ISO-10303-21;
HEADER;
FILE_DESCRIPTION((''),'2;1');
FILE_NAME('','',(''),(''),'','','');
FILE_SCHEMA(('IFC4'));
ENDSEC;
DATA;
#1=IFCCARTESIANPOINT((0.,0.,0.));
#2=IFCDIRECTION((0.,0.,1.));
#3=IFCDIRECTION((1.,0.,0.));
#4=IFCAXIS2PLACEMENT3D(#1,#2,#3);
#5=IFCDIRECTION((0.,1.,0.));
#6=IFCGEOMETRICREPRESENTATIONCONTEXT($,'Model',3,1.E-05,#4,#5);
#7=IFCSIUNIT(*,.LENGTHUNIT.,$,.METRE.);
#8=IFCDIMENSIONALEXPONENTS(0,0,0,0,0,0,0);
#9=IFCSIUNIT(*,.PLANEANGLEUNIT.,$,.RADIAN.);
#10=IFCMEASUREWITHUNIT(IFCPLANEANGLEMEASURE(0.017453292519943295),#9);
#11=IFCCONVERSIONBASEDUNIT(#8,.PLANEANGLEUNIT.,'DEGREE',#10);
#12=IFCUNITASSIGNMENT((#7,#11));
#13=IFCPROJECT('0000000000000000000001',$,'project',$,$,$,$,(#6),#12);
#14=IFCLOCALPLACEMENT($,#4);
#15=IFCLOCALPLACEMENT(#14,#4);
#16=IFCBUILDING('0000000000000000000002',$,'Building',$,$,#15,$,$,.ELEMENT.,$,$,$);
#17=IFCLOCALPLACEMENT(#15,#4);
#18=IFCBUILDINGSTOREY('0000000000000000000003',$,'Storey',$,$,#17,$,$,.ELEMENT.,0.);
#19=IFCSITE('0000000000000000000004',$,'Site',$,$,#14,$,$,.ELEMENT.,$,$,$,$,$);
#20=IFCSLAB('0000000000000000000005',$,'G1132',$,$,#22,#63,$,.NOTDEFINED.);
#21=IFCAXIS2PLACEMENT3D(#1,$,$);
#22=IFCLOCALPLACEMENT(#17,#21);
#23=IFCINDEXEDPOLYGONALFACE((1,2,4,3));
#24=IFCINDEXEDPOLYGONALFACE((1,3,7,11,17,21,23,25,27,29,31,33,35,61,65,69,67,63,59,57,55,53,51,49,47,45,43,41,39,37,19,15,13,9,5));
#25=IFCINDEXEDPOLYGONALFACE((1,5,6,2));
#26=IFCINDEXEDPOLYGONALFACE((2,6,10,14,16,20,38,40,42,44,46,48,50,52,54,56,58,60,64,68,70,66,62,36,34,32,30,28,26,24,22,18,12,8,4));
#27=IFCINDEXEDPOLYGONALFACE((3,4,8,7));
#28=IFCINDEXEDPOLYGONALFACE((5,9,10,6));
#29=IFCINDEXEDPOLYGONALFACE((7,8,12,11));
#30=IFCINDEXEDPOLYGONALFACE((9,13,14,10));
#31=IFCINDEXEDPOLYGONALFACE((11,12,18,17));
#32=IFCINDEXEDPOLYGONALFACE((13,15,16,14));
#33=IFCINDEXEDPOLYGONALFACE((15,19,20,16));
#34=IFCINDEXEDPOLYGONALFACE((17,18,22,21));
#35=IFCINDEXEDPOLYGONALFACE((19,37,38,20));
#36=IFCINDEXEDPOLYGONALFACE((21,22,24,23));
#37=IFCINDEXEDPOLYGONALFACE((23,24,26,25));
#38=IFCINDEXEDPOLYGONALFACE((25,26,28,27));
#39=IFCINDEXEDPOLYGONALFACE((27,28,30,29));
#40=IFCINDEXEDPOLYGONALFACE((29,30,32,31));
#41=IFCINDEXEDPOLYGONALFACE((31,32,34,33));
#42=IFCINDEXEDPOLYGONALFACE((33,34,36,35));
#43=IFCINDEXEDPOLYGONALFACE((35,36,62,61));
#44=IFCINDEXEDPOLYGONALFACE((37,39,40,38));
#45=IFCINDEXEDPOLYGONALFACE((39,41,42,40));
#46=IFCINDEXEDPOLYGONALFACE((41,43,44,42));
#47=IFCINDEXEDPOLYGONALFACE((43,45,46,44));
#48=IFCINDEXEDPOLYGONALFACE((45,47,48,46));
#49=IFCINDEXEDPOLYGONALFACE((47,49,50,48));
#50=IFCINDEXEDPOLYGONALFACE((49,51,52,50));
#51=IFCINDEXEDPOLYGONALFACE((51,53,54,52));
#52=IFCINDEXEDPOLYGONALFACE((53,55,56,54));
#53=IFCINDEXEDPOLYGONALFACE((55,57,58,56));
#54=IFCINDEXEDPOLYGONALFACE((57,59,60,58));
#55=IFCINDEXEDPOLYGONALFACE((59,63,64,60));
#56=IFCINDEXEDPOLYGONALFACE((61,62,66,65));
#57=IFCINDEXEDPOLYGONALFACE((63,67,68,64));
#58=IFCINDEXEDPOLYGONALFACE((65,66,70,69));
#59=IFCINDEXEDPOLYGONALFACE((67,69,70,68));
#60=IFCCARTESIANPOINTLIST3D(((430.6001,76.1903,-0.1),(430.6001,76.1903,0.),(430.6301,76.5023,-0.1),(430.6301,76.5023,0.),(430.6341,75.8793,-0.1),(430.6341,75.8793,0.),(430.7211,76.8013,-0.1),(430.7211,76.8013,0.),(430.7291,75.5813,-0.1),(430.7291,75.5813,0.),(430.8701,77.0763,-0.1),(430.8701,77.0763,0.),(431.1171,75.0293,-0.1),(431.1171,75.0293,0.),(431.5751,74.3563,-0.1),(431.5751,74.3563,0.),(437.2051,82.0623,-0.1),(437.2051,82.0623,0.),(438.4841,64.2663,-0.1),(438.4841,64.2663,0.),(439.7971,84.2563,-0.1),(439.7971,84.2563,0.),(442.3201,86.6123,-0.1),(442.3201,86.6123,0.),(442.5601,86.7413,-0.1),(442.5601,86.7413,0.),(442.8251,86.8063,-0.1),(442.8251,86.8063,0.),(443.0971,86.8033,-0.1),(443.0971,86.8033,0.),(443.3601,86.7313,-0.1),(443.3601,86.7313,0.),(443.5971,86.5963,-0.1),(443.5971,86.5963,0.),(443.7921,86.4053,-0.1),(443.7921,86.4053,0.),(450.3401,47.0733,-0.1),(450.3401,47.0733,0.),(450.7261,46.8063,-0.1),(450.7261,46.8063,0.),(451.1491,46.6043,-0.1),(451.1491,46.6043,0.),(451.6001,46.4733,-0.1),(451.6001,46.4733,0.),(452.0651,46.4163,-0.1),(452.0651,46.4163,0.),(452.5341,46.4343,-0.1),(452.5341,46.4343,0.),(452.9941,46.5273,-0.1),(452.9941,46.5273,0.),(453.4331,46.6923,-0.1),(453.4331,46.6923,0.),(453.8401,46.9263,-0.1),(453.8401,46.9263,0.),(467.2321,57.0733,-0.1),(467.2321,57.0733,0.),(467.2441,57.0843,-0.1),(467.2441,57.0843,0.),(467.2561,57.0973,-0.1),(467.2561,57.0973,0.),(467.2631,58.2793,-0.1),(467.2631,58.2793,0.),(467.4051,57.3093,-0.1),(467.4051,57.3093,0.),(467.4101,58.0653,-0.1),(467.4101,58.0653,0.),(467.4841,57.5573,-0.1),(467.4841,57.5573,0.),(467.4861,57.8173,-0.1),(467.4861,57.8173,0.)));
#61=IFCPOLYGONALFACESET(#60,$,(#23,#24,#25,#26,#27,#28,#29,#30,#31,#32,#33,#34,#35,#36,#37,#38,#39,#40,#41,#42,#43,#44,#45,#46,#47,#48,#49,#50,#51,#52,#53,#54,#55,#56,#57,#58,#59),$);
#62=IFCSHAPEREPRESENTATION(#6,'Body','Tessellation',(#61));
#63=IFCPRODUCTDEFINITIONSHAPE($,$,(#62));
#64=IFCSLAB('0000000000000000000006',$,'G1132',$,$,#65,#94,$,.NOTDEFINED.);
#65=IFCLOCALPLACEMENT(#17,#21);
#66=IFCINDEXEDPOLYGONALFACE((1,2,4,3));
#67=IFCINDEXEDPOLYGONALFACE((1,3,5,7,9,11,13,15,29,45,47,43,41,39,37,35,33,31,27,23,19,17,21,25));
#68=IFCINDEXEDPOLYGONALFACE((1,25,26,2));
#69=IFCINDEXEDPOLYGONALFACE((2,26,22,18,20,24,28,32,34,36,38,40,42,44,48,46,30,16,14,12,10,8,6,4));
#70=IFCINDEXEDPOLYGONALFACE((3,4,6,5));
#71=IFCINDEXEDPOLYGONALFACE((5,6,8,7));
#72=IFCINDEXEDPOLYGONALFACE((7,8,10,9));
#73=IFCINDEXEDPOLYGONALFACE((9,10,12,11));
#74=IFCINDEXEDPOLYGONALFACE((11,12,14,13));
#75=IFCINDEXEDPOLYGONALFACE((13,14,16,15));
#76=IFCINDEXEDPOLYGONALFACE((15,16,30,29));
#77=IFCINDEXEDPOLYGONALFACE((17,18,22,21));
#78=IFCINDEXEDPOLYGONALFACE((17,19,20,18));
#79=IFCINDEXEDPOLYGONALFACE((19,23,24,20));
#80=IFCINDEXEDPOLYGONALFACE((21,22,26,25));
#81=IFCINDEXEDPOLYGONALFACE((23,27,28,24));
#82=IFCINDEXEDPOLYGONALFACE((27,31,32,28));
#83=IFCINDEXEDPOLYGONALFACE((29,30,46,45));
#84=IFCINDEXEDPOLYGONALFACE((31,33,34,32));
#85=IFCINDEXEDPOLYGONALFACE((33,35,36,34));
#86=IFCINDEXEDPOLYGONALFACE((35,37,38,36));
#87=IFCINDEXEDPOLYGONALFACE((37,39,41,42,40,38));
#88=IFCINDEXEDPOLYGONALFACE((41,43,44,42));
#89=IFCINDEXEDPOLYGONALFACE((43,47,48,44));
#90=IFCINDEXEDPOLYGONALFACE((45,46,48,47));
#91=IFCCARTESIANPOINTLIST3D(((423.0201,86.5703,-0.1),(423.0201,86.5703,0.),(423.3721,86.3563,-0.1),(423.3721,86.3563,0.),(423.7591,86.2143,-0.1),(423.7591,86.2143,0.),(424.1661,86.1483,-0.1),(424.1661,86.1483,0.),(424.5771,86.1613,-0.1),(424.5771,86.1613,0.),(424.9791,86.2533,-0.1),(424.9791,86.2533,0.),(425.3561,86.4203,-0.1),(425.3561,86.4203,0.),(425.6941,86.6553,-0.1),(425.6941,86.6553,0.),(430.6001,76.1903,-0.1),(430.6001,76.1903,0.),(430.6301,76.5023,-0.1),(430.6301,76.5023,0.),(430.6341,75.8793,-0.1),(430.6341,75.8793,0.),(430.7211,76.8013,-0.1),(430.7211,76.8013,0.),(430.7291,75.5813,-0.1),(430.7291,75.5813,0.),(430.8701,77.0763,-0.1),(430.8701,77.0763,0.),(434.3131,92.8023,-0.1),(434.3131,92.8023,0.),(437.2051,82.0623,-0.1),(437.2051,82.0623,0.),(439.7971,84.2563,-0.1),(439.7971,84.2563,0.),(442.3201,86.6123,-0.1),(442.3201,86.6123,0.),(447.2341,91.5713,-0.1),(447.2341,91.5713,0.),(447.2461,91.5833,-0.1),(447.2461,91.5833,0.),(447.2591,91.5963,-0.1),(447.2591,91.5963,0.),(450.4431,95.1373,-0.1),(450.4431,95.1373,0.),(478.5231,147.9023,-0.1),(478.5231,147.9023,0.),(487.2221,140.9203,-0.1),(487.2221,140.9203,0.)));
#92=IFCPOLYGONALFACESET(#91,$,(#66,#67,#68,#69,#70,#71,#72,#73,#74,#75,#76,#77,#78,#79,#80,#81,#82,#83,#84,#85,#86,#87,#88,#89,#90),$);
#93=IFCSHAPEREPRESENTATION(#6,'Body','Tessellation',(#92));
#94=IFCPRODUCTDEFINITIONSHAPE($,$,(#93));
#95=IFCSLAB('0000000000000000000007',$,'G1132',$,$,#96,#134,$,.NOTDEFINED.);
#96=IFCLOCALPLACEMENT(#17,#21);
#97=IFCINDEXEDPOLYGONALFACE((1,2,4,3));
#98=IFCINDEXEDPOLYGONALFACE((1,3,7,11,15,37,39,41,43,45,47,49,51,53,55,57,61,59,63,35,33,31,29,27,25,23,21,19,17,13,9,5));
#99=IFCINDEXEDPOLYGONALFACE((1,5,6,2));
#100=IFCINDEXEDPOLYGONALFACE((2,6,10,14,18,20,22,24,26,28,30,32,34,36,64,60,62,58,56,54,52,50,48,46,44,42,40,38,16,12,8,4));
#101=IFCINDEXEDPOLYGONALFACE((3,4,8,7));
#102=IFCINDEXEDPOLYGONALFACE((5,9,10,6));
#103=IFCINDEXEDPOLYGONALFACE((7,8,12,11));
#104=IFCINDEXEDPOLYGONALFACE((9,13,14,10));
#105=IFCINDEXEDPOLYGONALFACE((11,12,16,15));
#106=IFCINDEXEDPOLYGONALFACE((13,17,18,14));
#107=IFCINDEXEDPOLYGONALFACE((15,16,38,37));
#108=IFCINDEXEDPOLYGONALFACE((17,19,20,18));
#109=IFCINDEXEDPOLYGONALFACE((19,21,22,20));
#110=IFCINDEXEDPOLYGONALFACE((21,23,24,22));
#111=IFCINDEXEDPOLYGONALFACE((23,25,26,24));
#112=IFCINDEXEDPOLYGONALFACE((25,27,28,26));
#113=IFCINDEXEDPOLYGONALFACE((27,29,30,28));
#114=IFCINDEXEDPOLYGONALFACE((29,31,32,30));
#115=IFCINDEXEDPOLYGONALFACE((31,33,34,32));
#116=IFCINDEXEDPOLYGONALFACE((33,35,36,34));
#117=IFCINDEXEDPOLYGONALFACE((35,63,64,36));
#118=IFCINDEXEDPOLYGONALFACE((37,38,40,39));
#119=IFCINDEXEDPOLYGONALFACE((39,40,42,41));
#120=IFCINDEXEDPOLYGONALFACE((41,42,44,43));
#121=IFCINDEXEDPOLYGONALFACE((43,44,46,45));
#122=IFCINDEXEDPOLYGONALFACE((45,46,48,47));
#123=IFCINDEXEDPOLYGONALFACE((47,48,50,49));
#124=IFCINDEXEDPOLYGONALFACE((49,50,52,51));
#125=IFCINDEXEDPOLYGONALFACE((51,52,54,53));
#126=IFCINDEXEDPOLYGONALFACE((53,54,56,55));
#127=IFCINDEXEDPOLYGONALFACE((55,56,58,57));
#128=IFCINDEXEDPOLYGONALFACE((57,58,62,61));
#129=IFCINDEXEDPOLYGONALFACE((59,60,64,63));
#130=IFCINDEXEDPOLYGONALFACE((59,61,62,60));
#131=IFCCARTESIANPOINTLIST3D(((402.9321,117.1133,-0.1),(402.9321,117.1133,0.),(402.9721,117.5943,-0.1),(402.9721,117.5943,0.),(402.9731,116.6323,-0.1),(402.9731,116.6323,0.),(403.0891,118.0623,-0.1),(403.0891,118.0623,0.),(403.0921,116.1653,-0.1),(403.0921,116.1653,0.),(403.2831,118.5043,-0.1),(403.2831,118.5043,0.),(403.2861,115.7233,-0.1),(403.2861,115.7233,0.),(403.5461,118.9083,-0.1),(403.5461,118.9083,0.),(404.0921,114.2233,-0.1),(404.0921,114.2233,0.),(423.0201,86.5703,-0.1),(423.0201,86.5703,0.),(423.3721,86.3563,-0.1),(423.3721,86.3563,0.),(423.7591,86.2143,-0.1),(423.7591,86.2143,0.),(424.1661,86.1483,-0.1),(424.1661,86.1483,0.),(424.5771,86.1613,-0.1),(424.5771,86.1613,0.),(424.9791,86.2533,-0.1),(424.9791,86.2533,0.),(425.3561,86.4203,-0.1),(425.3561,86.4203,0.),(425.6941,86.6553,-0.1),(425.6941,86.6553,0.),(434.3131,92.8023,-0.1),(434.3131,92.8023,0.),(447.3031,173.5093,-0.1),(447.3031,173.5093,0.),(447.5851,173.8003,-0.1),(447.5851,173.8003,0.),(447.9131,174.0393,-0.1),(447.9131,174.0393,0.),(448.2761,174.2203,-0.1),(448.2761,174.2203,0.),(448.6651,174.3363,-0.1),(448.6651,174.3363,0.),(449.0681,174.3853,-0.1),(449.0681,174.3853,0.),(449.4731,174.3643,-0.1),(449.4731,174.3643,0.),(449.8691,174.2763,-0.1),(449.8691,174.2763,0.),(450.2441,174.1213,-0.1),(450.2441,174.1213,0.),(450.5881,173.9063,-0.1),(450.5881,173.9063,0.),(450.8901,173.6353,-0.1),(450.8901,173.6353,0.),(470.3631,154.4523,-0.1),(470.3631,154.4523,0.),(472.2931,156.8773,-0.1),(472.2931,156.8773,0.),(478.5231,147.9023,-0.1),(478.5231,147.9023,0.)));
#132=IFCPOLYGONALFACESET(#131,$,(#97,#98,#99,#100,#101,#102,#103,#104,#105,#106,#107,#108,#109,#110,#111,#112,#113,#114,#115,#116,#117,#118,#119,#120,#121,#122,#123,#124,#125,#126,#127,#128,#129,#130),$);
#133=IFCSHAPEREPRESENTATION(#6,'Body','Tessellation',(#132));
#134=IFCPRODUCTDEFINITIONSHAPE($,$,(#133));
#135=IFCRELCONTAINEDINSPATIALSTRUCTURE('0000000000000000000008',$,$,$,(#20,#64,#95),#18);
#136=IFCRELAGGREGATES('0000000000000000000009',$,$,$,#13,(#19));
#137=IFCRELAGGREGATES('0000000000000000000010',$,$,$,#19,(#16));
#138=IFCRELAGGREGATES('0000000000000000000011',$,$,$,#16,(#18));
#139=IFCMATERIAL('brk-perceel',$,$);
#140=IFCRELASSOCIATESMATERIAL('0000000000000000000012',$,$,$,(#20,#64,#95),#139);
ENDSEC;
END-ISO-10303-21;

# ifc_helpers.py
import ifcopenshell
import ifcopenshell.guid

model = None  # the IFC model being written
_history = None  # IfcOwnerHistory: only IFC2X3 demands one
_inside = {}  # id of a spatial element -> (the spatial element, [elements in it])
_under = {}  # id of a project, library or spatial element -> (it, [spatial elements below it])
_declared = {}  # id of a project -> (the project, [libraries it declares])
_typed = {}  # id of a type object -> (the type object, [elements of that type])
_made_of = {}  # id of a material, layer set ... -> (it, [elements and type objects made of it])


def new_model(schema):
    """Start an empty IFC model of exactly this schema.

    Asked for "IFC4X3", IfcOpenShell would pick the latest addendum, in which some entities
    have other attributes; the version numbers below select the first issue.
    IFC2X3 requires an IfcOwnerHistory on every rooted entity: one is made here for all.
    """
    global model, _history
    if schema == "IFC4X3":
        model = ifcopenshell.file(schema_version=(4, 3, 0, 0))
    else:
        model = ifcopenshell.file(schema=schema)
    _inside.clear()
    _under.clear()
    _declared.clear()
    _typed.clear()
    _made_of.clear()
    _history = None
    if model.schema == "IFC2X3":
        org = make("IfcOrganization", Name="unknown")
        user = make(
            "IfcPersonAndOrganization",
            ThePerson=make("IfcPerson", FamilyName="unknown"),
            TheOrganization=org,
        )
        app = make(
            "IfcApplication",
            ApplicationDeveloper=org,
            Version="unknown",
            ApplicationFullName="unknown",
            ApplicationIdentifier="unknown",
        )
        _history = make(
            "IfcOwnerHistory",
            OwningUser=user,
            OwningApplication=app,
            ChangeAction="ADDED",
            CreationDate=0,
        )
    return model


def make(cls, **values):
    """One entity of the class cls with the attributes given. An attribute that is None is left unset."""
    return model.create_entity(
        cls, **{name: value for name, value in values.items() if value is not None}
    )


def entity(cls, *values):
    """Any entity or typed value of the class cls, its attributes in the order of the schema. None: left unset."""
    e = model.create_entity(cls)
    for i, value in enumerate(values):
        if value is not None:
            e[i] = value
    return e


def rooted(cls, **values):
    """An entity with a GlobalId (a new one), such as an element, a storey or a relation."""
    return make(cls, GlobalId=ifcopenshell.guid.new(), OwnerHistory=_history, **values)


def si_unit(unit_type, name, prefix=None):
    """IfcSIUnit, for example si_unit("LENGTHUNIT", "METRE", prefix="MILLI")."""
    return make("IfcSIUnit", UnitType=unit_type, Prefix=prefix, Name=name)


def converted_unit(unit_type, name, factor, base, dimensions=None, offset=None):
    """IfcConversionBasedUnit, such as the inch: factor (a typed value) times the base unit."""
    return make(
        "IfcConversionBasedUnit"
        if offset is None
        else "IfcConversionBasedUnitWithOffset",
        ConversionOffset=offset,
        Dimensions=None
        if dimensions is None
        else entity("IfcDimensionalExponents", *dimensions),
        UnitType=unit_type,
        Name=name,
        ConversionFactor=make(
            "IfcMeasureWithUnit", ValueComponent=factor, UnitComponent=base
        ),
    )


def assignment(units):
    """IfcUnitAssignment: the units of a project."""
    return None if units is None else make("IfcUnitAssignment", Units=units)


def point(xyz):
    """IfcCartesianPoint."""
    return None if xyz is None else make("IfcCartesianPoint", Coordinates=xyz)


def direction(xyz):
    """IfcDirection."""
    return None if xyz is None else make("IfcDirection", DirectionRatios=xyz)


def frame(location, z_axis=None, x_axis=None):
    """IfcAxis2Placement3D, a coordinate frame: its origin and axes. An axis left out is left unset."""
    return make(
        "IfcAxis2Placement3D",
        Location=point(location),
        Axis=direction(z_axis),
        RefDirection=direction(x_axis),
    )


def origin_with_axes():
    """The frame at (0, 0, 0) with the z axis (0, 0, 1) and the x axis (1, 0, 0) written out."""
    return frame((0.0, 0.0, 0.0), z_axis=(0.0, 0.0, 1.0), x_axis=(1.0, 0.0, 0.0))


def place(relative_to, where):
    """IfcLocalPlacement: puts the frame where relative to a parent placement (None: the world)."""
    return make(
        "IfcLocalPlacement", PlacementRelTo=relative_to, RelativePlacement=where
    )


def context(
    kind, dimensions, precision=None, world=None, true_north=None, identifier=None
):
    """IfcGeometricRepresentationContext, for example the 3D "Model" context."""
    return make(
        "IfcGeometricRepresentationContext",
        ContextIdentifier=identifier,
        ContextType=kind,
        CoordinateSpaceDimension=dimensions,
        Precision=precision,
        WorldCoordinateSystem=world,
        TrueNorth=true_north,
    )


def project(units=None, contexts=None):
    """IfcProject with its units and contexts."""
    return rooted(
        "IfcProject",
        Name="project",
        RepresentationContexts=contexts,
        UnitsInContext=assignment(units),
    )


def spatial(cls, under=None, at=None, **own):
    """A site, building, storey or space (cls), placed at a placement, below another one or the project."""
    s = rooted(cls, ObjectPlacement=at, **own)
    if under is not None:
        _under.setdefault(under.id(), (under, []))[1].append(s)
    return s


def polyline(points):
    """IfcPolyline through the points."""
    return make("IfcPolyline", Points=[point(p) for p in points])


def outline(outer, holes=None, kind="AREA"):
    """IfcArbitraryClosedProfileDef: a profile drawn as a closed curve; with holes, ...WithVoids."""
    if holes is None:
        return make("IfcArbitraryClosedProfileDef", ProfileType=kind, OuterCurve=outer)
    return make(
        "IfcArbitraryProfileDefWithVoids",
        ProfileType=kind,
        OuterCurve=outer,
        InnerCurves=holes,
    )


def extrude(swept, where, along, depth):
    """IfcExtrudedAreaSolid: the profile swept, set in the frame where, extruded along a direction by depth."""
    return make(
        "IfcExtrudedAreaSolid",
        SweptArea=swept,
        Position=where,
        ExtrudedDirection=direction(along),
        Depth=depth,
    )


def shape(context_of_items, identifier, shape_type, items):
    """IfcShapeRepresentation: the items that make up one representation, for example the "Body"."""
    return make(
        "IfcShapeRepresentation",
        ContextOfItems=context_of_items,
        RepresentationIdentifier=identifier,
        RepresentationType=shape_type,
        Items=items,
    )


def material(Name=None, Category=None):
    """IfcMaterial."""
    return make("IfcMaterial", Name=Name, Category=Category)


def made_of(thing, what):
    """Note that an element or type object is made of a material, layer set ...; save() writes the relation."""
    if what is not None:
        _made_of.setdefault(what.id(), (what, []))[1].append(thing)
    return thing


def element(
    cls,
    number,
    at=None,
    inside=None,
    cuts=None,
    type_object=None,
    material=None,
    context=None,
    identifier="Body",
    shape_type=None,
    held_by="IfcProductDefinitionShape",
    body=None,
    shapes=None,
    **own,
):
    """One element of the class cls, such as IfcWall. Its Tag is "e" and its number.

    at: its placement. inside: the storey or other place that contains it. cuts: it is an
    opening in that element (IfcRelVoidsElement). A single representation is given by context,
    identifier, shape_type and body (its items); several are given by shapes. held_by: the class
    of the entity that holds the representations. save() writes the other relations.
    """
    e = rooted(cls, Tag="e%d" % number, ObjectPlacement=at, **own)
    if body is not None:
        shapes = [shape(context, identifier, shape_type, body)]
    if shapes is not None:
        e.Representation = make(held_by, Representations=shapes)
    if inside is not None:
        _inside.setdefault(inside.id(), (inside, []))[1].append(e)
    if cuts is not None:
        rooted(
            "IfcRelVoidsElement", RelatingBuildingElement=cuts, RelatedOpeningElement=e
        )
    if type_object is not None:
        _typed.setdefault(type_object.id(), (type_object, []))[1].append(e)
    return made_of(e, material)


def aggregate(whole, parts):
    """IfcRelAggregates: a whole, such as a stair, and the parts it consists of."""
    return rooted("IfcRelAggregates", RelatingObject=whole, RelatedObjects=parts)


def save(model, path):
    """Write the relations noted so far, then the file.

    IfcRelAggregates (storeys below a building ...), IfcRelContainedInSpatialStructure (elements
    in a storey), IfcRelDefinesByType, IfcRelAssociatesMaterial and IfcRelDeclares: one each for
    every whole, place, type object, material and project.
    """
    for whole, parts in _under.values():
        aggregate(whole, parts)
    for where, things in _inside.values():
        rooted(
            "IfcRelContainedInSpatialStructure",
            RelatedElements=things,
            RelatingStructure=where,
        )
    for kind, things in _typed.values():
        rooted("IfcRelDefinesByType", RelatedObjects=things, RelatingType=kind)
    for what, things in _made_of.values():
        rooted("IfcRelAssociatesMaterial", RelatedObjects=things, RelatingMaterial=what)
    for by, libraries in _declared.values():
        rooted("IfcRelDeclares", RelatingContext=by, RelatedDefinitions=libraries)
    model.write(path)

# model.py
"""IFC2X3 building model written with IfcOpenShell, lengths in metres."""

from ifc_helpers import new_model, entity, si_unit, converted_unit, direction, frame, origin_with_axes, place, context, project, spatial, polyline, outline, extrude, material, element, save


model = new_model("IFC2X3")

# Units and contexts
model_context = context("Model", 3, precision=1e-05, world=origin_with_axes(), true_north=direction((0.0, 1.0, 0.0)))
ifc_project = project(units=[si_unit("LENGTHUNIT", "METRE"), converted_unit("PLANEANGLEUNIT", "DEGREE", entity("IfcPlaneAngleMeasure", 0.017453292519943295), si_unit("PLANEANGLEUNIT", "RADIAN"), dimensions=[0, 0, 0, 0, 0, 0, 0])], contexts=[model_context])

# Site, building, storey
site_placement = place(None, origin_with_axes())
site = spatial("IfcSite", under=ifc_project, at=site_placement, Name="Site", CompositionType="ELEMENT")
building_placement = place(site_placement, origin_with_axes())
building = spatial("IfcBuilding", under=site, at=building_placement, Name="Building", CompositionType="ELEMENT")
storey_placement = place(building_placement, origin_with_axes())
storey = spatial("IfcBuildingStorey", under=building, at=storey_placement, Name="Storey", CompositionType="ELEMENT", Elevation=0.0)

# Slabs
ifc_material = material(Name="brk-perceel")
slab_1_placement = place(storey_placement, frame((0.0, 0.0, -0.1), z_axis=(0.0, 0.0, 1.0), x_axis=(1.0, 0.0, 0.0)))
element("IfcSlab", 1, at=slab_1_placement, inside=storey, material=ifc_material, Name="G1132", PredefinedType="NOTDEFINED", context=model_context, shape_type="SweptSolid", body=[
    extrude(outline(polyline([(467.2441, 57.0843), (467.2321, 57.0733), (453.8401, 46.9263), (453.4331, 46.6923), (452.9941, 46.5273), (452.5341, 46.4343), (452.0651, 46.4163), (451.6001, 46.4733), (451.1491, 46.6043), (450.7261, 46.8063), (450.3401, 47.0733), (438.4841, 64.2663), (431.5751, 74.3563), (431.1171, 75.0293), (430.7291, 75.5813), (430.6341, 75.8793), (430.6001, 76.1903), (430.6301, 76.5023), (430.7211, 76.8013), (430.8701, 77.0763), (437.2051, 82.0623), (439.7971, 84.2563), (442.3201, 86.6123), (442.5601, 86.7413), (442.8251, 86.8063), (443.0971, 86.8033), (443.3601, 86.7313), (443.5971, 86.5963), (443.7921, 86.4053), (467.2631, 58.2793), (467.4101, 58.0653), (467.4861, 57.8173), (467.4841, 57.5573), (467.4051, 57.3093), (467.2561, 57.0973), (467.2441, 57.0843)])), origin_with_axes(), (0.0, 0.0, 1.0), 0.1),
])
slab_2_placement = place(storey_placement, frame((0.0, 0.0, -0.1), z_axis=(0.0, 0.0, 1.0), x_axis=(1.0, 0.0, 0.0)))
element("IfcSlab", 2, at=slab_2_placement, inside=storey, material=ifc_material, Name="G1132", PredefinedType="NOTDEFINED", context=model_context, shape_type="SweptSolid", body=[
    extrude(outline(polyline([(450.4431, 95.1373), (447.2591, 91.5963), (447.2461, 91.5833), (447.2341, 91.5713), (442.3201, 86.6123), (439.7971, 84.2563), (437.2051, 82.0623), (430.8701, 77.0763), (430.7211, 76.8013), (430.6301, 76.5023), (430.6001, 76.1903), (430.6341, 75.8793), (430.7291, 75.5813), (423.0201, 86.5703), (423.3721, 86.3563), (423.7591, 86.2143), (424.1661, 86.1483), (424.5771, 86.1613), (424.9791, 86.2533), (425.3561, 86.4203), (425.6941, 86.6553), (434.3131, 92.8023), (478.5231, 147.9023), (487.2221, 140.9203), (450.4431, 95.1373)])), origin_with_axes(), (0.0, 0.0, 1.0), 0.1),
])
slab_3_placement = place(storey_placement, frame((0.0, 0.0, -0.1), z_axis=(0.0, 0.0, 1.0), x_axis=(1.0, 0.0, 0.0)))
element("IfcSlab", 3, at=slab_3_placement, inside=storey, material=ifc_material, Name="G1132", PredefinedType="NOTDEFINED", context=model_context, shape_type="SweptSolid", body=[
    extrude(outline(polyline([(470.3631, 154.4523), (478.5231, 147.9023), (434.3131, 92.8023), (425.6941, 86.6553), (425.3561, 86.4203), (424.9791, 86.2533), (424.5771, 86.1613), (424.1661, 86.1483), (423.7591, 86.2143), (423.3721, 86.3563), (423.0201, 86.5703), (404.0921, 114.2233), (403.2861, 115.7233), (403.0921, 116.1653), (402.9731, 116.6323), (402.9321, 117.1133), (402.9721, 117.5943), (403.0891, 118.0623), (403.2831, 118.5043), (403.5461, 118.9083), (447.3031, 173.5093), (447.5851, 173.8003), (447.9131, 174.0393), (448.2761, 174.2203), (448.6651, 174.3363), (449.0681, 174.3853), (449.4731, 174.3643), (449.8691, 174.2763), (450.2441, 174.1213), (450.5881, 173.9063), (450.8901, 173.6353), (472.2931, 156.8773), (470.3631, 154.4523)])), origin_with_axes(), (0.0, 0.0, 1.0), 0.1),
])

save(model, "model.ifc")
